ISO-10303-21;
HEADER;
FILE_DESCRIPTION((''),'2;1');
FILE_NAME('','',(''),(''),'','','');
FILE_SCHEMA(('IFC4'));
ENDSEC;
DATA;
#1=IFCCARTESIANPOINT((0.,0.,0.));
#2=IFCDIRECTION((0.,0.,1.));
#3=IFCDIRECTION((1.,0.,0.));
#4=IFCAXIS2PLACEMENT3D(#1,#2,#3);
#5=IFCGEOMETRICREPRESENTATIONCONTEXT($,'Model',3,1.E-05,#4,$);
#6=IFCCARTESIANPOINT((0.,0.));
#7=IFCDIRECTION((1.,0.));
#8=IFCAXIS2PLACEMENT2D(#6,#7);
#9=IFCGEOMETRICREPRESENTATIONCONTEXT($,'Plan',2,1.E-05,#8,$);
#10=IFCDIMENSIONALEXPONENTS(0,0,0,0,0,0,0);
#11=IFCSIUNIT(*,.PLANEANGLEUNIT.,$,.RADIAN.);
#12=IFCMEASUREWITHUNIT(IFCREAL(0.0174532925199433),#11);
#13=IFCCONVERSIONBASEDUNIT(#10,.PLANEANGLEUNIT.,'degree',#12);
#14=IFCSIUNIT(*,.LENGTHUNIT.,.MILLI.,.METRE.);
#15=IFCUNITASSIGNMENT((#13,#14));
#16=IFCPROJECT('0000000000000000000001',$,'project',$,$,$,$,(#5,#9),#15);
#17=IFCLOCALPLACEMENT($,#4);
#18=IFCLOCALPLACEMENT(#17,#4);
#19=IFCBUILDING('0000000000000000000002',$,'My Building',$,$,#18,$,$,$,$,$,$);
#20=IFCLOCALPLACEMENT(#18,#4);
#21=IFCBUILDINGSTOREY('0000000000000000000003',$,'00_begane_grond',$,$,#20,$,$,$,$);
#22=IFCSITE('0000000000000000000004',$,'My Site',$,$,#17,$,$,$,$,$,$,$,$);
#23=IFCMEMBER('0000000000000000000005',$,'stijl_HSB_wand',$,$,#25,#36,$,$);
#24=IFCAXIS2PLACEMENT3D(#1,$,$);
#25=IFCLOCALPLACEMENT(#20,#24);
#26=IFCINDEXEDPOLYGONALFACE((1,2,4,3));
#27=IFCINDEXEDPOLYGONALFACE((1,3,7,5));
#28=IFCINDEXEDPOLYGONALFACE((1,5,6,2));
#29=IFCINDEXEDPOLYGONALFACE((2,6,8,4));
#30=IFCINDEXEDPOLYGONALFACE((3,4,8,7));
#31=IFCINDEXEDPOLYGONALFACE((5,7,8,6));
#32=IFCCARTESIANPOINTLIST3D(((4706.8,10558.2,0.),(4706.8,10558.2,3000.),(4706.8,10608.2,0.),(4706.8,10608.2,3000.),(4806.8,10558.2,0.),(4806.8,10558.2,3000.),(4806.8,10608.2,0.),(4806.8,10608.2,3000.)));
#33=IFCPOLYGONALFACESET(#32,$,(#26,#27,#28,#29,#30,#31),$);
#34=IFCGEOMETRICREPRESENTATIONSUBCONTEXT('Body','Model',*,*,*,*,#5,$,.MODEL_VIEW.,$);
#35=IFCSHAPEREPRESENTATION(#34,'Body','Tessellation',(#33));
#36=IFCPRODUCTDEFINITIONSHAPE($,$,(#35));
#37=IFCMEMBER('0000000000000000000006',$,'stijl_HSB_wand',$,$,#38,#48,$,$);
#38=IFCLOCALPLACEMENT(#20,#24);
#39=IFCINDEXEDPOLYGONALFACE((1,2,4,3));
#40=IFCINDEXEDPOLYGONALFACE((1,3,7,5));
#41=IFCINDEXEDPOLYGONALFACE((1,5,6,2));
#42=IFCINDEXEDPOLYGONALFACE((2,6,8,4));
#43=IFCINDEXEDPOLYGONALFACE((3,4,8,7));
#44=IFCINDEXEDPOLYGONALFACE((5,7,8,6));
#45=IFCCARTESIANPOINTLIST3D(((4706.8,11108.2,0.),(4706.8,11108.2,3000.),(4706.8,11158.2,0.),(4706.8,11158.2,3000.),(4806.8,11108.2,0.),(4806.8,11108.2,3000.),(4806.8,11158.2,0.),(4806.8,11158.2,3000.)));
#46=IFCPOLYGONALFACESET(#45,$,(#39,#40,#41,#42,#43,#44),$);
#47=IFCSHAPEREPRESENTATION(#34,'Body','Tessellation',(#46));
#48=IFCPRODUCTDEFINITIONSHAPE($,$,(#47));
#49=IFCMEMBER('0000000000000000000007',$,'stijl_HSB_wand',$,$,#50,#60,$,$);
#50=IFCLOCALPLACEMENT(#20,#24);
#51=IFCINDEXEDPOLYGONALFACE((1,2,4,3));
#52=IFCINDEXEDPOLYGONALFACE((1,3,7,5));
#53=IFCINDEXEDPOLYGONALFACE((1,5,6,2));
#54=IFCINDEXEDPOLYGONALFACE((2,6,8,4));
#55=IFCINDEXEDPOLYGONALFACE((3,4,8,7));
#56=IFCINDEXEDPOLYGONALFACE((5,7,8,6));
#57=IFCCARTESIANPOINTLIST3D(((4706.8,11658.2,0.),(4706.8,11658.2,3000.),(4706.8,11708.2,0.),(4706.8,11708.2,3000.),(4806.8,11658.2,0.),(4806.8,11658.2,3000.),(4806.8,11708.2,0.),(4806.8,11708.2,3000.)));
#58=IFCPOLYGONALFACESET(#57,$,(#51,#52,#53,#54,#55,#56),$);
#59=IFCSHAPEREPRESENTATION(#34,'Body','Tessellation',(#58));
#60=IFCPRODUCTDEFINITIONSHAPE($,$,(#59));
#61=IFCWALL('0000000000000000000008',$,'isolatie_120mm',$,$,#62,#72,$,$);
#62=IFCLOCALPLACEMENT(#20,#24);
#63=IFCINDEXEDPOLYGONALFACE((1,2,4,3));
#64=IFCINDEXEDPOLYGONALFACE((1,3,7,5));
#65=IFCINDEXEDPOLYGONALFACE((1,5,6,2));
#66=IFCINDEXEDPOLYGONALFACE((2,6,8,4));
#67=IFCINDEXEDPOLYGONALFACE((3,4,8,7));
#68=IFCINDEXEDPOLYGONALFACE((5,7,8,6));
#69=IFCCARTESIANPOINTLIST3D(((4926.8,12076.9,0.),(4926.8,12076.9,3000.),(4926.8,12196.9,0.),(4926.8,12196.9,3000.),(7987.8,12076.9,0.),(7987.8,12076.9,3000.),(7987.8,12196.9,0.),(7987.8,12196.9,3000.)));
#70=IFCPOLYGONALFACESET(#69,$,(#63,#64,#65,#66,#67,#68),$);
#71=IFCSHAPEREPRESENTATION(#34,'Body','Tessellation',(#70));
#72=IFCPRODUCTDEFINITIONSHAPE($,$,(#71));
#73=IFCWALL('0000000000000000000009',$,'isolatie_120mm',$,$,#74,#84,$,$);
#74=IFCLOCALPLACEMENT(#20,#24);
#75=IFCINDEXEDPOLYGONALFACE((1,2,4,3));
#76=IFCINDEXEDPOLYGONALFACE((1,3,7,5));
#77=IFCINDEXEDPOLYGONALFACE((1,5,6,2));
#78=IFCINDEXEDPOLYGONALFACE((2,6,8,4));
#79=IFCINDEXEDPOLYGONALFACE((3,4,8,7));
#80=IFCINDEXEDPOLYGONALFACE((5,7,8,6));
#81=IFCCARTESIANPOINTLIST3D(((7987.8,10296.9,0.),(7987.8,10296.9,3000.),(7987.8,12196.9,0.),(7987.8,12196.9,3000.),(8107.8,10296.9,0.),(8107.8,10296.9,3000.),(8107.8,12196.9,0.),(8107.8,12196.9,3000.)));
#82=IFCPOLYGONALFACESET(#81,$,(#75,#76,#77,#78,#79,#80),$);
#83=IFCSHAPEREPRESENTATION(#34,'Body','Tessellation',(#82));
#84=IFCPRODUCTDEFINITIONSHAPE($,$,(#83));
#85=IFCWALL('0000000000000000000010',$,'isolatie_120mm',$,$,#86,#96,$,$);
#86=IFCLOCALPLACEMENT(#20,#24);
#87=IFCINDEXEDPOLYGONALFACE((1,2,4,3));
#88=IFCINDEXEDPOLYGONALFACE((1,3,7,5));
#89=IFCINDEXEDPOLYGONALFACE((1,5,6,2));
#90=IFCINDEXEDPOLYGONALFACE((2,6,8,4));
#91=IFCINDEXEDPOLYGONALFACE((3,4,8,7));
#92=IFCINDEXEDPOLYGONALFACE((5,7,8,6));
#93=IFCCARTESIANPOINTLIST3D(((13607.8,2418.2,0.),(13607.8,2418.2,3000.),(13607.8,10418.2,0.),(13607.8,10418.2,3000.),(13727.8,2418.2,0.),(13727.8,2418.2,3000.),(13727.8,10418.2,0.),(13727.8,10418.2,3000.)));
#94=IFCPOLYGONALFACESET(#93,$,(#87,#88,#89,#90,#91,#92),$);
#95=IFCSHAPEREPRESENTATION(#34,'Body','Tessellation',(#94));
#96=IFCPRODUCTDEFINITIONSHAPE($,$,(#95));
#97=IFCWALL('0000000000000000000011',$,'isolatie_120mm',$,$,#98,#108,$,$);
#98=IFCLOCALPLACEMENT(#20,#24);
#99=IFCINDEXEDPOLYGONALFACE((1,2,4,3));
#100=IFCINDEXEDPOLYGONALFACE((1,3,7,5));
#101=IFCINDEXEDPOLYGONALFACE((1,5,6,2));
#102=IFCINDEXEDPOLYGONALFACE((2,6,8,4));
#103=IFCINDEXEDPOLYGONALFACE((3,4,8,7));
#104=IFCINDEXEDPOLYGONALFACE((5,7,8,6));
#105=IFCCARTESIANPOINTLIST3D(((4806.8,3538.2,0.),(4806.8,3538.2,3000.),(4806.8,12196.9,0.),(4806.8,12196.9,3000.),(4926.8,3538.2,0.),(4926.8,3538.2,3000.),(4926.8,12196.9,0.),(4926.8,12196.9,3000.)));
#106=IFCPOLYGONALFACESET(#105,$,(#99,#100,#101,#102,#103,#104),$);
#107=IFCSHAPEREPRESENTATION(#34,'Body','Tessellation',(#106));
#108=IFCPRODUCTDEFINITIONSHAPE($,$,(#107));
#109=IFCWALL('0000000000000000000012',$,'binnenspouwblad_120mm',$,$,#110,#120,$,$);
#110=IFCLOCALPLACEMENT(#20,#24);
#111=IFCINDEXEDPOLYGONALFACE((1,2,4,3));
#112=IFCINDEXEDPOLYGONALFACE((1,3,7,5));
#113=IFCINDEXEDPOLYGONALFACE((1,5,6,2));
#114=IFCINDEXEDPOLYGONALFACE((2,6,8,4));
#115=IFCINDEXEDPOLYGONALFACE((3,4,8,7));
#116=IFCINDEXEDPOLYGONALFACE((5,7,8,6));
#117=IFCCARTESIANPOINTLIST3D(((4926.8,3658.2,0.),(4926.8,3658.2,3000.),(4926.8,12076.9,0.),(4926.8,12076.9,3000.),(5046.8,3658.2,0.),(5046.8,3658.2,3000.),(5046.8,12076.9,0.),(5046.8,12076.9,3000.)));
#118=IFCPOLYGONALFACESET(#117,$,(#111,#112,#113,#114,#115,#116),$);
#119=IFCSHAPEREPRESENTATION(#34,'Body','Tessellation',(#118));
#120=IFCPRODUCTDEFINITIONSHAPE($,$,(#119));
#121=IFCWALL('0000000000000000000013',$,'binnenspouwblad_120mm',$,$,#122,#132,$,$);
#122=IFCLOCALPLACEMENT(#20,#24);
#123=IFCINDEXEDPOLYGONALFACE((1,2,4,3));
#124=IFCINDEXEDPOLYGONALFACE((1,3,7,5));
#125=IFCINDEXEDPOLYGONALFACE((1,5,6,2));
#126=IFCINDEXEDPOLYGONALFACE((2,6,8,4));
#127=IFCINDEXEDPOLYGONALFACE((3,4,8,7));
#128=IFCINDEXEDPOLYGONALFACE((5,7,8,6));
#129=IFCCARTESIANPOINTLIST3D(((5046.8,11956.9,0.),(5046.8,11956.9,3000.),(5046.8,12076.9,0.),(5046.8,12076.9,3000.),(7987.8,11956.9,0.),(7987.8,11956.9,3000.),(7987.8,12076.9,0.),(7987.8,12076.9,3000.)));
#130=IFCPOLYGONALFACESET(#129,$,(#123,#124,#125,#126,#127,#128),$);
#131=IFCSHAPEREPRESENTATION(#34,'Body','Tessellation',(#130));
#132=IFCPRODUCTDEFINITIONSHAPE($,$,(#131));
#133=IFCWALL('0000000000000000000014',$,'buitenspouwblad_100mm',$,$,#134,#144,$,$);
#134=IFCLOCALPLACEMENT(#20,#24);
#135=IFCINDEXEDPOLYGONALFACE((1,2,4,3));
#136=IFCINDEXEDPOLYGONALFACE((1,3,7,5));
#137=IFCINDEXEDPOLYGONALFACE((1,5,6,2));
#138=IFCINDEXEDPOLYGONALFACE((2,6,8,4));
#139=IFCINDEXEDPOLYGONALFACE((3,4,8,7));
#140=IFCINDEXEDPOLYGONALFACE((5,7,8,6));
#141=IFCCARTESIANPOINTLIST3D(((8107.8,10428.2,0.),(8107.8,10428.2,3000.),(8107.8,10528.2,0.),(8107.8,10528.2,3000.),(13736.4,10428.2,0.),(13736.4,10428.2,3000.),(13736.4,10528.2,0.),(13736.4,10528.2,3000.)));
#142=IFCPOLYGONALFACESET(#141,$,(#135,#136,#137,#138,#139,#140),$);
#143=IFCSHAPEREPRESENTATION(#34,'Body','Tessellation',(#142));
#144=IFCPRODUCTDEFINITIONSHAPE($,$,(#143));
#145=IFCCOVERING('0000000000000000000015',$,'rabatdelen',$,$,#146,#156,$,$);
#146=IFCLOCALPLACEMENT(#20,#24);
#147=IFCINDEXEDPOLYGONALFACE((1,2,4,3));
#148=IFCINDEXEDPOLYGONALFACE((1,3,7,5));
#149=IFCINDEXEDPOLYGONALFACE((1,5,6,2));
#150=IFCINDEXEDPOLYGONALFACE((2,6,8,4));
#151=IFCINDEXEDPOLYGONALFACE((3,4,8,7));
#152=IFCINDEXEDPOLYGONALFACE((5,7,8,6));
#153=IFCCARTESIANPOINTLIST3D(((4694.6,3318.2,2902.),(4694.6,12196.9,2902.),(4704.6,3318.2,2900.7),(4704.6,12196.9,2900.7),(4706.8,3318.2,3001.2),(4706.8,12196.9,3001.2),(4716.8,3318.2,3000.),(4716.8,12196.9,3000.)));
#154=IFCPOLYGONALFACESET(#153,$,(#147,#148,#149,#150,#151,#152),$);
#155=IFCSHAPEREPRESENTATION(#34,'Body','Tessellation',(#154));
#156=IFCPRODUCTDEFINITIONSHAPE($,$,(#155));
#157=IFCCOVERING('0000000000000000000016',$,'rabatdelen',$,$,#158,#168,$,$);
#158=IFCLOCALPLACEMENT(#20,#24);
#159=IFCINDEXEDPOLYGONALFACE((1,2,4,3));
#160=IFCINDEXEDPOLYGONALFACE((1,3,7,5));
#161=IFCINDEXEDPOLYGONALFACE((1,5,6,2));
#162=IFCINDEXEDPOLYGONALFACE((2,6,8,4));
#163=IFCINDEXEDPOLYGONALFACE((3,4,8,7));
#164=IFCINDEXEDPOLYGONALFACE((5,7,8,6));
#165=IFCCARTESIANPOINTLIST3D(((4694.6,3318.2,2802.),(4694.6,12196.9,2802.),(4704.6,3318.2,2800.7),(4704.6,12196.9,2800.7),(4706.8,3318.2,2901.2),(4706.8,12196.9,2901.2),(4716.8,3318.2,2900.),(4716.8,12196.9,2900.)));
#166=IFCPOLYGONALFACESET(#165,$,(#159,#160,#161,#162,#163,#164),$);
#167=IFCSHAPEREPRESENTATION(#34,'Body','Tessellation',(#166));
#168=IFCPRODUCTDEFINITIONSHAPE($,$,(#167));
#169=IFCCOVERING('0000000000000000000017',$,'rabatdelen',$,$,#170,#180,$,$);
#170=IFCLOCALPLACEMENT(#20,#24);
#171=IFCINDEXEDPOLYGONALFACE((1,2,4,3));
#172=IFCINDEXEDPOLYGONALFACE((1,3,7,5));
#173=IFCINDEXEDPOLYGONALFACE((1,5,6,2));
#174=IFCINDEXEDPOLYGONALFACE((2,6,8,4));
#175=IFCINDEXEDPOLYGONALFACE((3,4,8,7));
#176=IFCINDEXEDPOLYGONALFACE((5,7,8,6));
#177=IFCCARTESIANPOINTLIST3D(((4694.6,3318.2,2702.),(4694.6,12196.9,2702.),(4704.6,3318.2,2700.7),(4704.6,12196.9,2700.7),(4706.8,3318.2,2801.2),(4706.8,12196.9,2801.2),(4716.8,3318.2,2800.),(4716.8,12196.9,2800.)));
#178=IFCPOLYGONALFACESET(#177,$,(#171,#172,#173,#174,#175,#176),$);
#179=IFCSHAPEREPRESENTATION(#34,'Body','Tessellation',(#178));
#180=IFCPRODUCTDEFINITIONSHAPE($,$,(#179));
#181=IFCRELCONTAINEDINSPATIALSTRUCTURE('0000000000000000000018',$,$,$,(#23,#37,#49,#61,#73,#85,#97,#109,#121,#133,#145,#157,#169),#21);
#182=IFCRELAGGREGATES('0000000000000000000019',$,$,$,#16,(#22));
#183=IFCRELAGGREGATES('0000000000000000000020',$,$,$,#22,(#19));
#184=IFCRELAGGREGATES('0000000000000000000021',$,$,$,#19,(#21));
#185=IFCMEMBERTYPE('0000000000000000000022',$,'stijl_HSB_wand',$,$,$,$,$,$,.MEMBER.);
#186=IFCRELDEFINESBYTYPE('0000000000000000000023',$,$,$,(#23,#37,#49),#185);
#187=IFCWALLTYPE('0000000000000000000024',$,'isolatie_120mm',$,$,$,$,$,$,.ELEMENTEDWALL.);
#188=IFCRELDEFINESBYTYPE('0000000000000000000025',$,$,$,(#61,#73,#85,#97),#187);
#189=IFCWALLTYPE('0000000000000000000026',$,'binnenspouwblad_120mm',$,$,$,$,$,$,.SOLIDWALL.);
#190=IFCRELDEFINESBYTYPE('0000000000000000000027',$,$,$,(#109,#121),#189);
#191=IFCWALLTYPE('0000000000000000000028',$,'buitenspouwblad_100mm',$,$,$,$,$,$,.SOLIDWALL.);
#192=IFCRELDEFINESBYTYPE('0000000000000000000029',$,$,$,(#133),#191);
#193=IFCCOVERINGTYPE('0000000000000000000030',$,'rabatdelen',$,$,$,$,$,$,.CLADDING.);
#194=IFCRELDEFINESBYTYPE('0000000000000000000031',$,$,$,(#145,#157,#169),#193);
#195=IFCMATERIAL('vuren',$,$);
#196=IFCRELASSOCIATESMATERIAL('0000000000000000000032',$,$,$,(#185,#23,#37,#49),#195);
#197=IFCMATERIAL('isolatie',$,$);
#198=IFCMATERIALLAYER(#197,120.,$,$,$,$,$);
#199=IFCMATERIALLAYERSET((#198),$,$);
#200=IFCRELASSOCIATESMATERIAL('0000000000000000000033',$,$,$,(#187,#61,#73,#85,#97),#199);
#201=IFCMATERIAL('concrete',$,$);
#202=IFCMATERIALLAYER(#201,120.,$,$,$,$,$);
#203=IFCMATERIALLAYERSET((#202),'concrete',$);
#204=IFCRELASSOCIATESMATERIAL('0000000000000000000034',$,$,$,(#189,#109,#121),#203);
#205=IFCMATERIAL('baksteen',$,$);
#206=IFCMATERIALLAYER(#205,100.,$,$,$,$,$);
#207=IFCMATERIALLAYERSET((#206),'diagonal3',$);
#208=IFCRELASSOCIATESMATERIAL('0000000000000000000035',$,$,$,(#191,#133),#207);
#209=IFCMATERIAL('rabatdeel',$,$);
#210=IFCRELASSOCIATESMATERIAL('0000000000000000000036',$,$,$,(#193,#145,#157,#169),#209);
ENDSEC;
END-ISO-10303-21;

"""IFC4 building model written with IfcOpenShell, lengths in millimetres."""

from ifc_helpers import new_model, entity, si_unit, converted_unit, frame, origin_with_axes, origin_2d_with_axis, place, context, subcontext, project, spatial, indexed_curve, rectangle, outline, extrude, material, layer, layer_set, layer_usage, material_profile, profile_set, profile_usage, type_object, element, save


model = new_model("IFC4")

# Units and contexts
model_context = context("Model", 3, precision=1e-05, world=origin_with_axes())
plan_context = context("Plan", 2, precision=1e-05, world=origin_2d_with_axis())
body_context = subcontext(model_context, "Body", "Model", "MODEL_VIEW")
ifc_project = project(units=[converted_unit("PLANEANGLEUNIT", "degree", entity("IfcReal", 0.0174532925199433), si_unit("PLANEANGLEUNIT", "RADIAN"), dimensions=[0, 0, 0, 0, 0, 0, 0]), si_unit("LENGTHUNIT", "METRE", prefix="MILLI")], contexts=[model_context, plan_context])

# Site, building, storey
site_placement = place(None, origin_with_axes())
site = spatial("IfcSite", under=ifc_project, at=site_placement, Name="My Site")
building_placement = place(site_placement, origin_with_axes())
building = spatial("IfcBuilding", under=site, at=building_placement, Name="My Building")
storey_placement = place(building_placement, origin_with_axes())
storey = spatial("IfcBuildingStorey", under=building, at=storey_placement, Name="00_begane_grond")

# Members
ifc_material_1 = material(Name="vuren")
ifc_material_profile_1 = material_profile(ifc_material_1, rectangle(XDim=100.0, YDim=50.0))
ifc_material_profile_2 = material_profile(ifc_material_1, rectangle(XDim=100.0, YDim=50.0))
ifc_profile_set_1 = profile_set([ifc_material_profile_1, ifc_material_profile_2])
ifc_profile_usage_1 = profile_usage(ifc_profile_set_1, cardinal=1)
member_type = type_object("IfcMemberType", Name="stijl_HSB_wand", PredefinedType="MEMBER", material=ifc_profile_set_1)
member_1_placement = place(storey_placement, frame((4806.8, 10558.2, 0.0), z_axis=(0.0, 0.0, 1.0), x_axis=(1.0, 0.0, 0.0)))
element("IfcMember", 1, at=member_1_placement, inside=storey, type_object=member_type, material=ifc_profile_usage_1, Name="stijl_HSB_wand", context=body_context, shape_type="SweptSolid", body=[
    extrude(rectangle(XDim=100.0, YDim=50.0), frame((-50.0, 25.0, 0.0), z_axis=(0.0, 0.0, 1.0), x_axis=(1.0, 0.0, 0.0)), (0.0, 0.0, 1.0), 3000.0),
])
ifc_profile_usage_2 = profile_usage(ifc_profile_set_1, cardinal=1)
member_2_placement = place(storey_placement, frame((4806.8, 11108.2, 0.0), z_axis=(0.0, 0.0, 1.0), x_axis=(1.0, 0.0, 0.0)))
element("IfcMember", 2, at=member_2_placement, inside=storey, type_object=member_type, material=ifc_profile_usage_2, Name="stijl_HSB_wand", context=body_context, shape_type="SweptSolid", body=[
    extrude(rectangle(XDim=100.0, YDim=50.0), frame((-50.0, 25.0, 0.0), z_axis=(0.0, 0.0, 1.0), x_axis=(1.0, 0.0, 0.0)), (0.0, 0.0, 1.0), 3000.0),
])
ifc_profile_usage_3 = profile_usage(ifc_profile_set_1, cardinal=1)
member_3_placement = place(storey_placement, frame((4806.8, 11658.2, 0.0), z_axis=(0.0, 0.0, 1.0), x_axis=(1.0, 0.0, 0.0)))
element("IfcMember", 3, at=member_3_placement, inside=storey, type_object=member_type, material=ifc_profile_usage_3, Name="stijl_HSB_wand", context=body_context, shape_type="SweptSolid", body=[
    extrude(rectangle(XDim=100.0, YDim=50.0), frame((-50.0, 25.0, 0.0), z_axis=(0.0, 0.0, 1.0), x_axis=(1.0, 0.0, 0.0)), (0.0, 0.0, 1.0), 3000.0),
])

# Walls
ifc_material_2 = material(Name="isolatie")
ifc_layer_1 = layer(ifc_material_2, 120.0)
ifc_layer_set_1 = layer_set([ifc_layer_1])
ifc_layer_usage_1 = layer_usage(ifc_layer_set_1, "AXIS2", "POSITIVE", 0.0)
wall_type_1 = type_object("IfcWallType", Name="isolatie_120mm", PredefinedType="ELEMENTEDWALL", material=ifc_layer_set_1)
wall_1_placement = place(storey_placement, frame((4926.8, 12076.9, 0.0), z_axis=(0.0, 0.0, 1.0), x_axis=(1.0, 0.0, 0.0)))
element("IfcWall", 4, at=wall_1_placement, inside=storey, type_object=wall_type_1, material=ifc_layer_usage_1, Name="isolatie_120mm", context=body_context, shape_type="SweptSolid", body=[
    extrude(outline(indexed_curve([(0.0, 0.0), (0.0, 120.0), (3061.0, 120.0), (3061.0, 0.0), (0.0, 0.0)], self_intersect=False)), origin_with_axes(), (0.0, 0.0, 1.0), 3000.0),
])
ifc_layer_usage_2 = layer_usage(ifc_layer_set_1, "AXIS2", "POSITIVE", 0.0)
wall_2_placement = place(storey_placement, frame((7987.8, 12196.9, 0.0), z_axis=(0.0, 0.0, 1.0), x_axis=(-0.000001, -1.0, 0.0)))
element("IfcWall", 5, at=wall_2_placement, inside=storey, type_object=wall_type_1, material=ifc_layer_usage_2, Name="isolatie_120mm", context=body_context, shape_type="SweptSolid", body=[
    extrude(outline(indexed_curve([(0.0, 0.0), (0.0, 120.0), (1900.0, 120.0), (1900.0, 0.0), (0.0, 0.0)], self_intersect=False)), origin_with_axes(), (0.0, 0.0, 1.0), 3000.0),
])
ifc_layer_usage_3 = layer_usage(ifc_layer_set_1, "AXIS2", "POSITIVE", 0.0)
wall_3_placement = place(storey_placement, frame((13607.8, 10418.2, 0.0), z_axis=(0.0, 0.0, 1.0), x_axis=(-0.000001, -1.0, 0.0)))
element("IfcWall", 6, at=wall_3_placement, inside=storey, type_object=wall_type_1, material=ifc_layer_usage_3, Name="isolatie_120mm", context=body_context, shape_type="SweptSolid", body=[
    extrude(outline(indexed_curve([(0.0, 0.0), (0.0, 120.0), (8000.0, 120.0), (8000.0, 0.0), (0.0, 0.0)], self_intersect=False)), origin_with_axes(), (0.0, 0.0, 1.0), 3000.0),
])
ifc_layer_usage_4 = layer_usage(ifc_layer_set_1, "AXIS2", "POSITIVE", 0.0)
wall_4_placement = place(storey_placement, frame((4806.8, 12196.9, 0.0), z_axis=(0.0, 0.0, 1.0), x_axis=(0.0, -1.0, 0.0)))
element("IfcWall", 7, at=wall_4_placement, inside=storey, type_object=wall_type_1, material=ifc_layer_usage_4, Name="isolatie_120mm", context=body_context, shape_type="SweptSolid", body=[
    extrude(outline(indexed_curve([(0.0, 0.0), (0.0, 120.0), (8658.8, 120.0), (8658.8, 0.0), (0.0, 0.0)], self_intersect=False)), origin_with_axes(), (0.0, 0.0, 1.0), 3000.0),
])
ifc_material_3 = material(Name="concrete")
ifc_layer_2 = layer(ifc_material_3, 120.0)
ifc_layer_set_2 = layer_set([ifc_layer_2], Name="concrete")
ifc_layer_usage_5 = layer_usage(ifc_layer_set_2, "AXIS2", "POSITIVE", 0.0)
wall_type_2 = type_object("IfcWallType", Name="binnenspouwblad_120mm", PredefinedType="SOLIDWALL", material=ifc_layer_set_2)
wall_5_placement = place(storey_placement, frame((4926.8, 12076.9, 0.0), z_axis=(0.0, 0.0, 1.0), x_axis=(-0.000001, -1.0, 0.0)))
element("IfcWall", 8, at=wall_5_placement, inside=storey, type_object=wall_type_2, material=ifc_layer_usage_5, Name="binnenspouwblad_120mm", context=body_context, shape_type="SweptSolid", body=[
    extrude(outline(indexed_curve([(0.0, 0.0), (0.0, 120.0), (8418.7, 120.0), (8418.7, 0.0), (0.0, 0.0)], self_intersect=False)), origin_with_axes(), (0.0, 0.0, 1.0), 3000.0),
])
ifc_layer_usage_6 = layer_usage(ifc_layer_set_2, "AXIS2", "POSITIVE", 0.0)
wall_6_placement = place(storey_placement, frame((7987.8, 12076.9, 0.0), z_axis=(0.0, 0.0, 1.0), x_axis=(-1.0, 0.000002, 0.0)))
element("IfcWall", 9, at=wall_6_placement, inside=storey, type_object=wall_type_2, material=ifc_layer_usage_6, Name="binnenspouwblad_120mm", context=body_context, shape_type="SweptSolid", body=[
    extrude(outline(indexed_curve([(0.0, 0.0), (0.0, 120.0), (2941.0, 120.0), (2941.0, 0.0), (0.0, 0.0)], self_intersect=False)), origin_with_axes(), (0.0, 0.0, 1.0), 3000.0),
])
ifc_material_4 = material(Name="baksteen")
ifc_layer_3 = layer(ifc_material_4, 100.0)
ifc_layer_set_3 = layer_set([ifc_layer_3], Name="diagonal3")
ifc_layer_usage_7 = layer_usage(ifc_layer_set_3, "AXIS2", "POSITIVE", 0.0)
wall_type_3 = type_object("IfcWallType", Name="buitenspouwblad_100mm", PredefinedType="SOLIDWALL", material=ifc_layer_set_3)
wall_7_placement = place(storey_placement, frame((13736.4, 10528.2, 0.0), z_axis=(0.0, 0.0, 1.0), x_axis=(-1.0, 0.0, 0.0)))
element("IfcWall", 10, at=wall_7_placement, inside=storey, type_object=wall_type_3, material=ifc_layer_usage_7, Name="buitenspouwblad_100mm", context=body_context, shape_type="SweptSolid", body=[
    extrude(outline(indexed_curve([(0.0, 0.0), (0.0, 100.0), (5628.7, 100.0), (5628.7, 0.0), (0.0, 0.0)], self_intersect=False)), origin_with_axes(), (0.0, 0.0, 1.0), 3000.0),
])

# Coverings
ifc_material_5 = material(Name="rabatdeel")
ifc_material_profile_3 = material_profile(ifc_material_5, rectangle(XDim=10.0, YDim=100.0))
ifc_profile_set_2 = profile_set([ifc_material_profile_3])
ifc_profile_usage_4 = profile_usage(ifc_profile_set_2, cardinal=7)
covering_type = type_object("IfcCoveringType", Name="rabatdelen", PredefinedType="CLADDING", material=ifc_profile_set_2)
covering_1_placement = place(storey_placement, frame((4716.8, 12196.9, 3000.0), z_axis=(0.0, -1.0, 0.0), x_axis=(0.992546, 0.0, -0.121869)))
element("IfcCovering", 11, at=covering_1_placement, inside=storey, type_object=covering_type, material=ifc_profile_usage_4, Name="rabatdelen", context=body_context, shape_type="SweptSolid", body=[
    extrude(rectangle(XDim=10.0, YDim=100.0), frame((-5.0, -50.0, 0.0), z_axis=(0.0, 0.0, 1.0), x_axis=(1.0, 0.0, 0.0)), (0.0, 0.0, 1.0), 8878.8),
])
ifc_profile_usage_5 = profile_usage(ifc_profile_set_2, cardinal=7)
covering_2_placement = place(storey_placement, frame((4716.8, 12196.9, 2900.0), z_axis=(0.0, -1.0, 0.0), x_axis=(0.992546, 0.0, -0.121869)))
element("IfcCovering", 12, at=covering_2_placement, inside=storey, type_object=covering_type, material=ifc_profile_usage_5, Name="rabatdelen", context=body_context, shape_type="SweptSolid", body=[
    extrude(rectangle(XDim=10.0, YDim=100.0), frame((-5.0, -50.0, 0.0), z_axis=(0.0, 0.0, 1.0), x_axis=(1.0, 0.0, 0.0)), (0.0, 0.0, 1.0), 8878.8),
])
ifc_profile_usage_6 = profile_usage(ifc_profile_set_2, cardinal=7)
covering_3_placement = place(storey_placement, frame((4716.8, 12196.9, 2800.0), z_axis=(0.0, -1.0, 0.0), x_axis=(0.992546, 0.0, -0.121869)))
element("IfcCovering", 13, at=covering_3_placement, inside=storey, type_object=covering_type, material=ifc_profile_usage_6, Name="rabatdelen", context=body_context, shape_type="SweptSolid", body=[
    extrude(rectangle(XDim=10.0, YDim=100.0), frame((-5.0, -50.0, 0.0), z_axis=(0.0, 0.0, 1.0), x_axis=(1.0, 0.0, 0.0)), (0.0, 0.0, 1.0), 8878.8),
])

save(model, "model.ifc")
